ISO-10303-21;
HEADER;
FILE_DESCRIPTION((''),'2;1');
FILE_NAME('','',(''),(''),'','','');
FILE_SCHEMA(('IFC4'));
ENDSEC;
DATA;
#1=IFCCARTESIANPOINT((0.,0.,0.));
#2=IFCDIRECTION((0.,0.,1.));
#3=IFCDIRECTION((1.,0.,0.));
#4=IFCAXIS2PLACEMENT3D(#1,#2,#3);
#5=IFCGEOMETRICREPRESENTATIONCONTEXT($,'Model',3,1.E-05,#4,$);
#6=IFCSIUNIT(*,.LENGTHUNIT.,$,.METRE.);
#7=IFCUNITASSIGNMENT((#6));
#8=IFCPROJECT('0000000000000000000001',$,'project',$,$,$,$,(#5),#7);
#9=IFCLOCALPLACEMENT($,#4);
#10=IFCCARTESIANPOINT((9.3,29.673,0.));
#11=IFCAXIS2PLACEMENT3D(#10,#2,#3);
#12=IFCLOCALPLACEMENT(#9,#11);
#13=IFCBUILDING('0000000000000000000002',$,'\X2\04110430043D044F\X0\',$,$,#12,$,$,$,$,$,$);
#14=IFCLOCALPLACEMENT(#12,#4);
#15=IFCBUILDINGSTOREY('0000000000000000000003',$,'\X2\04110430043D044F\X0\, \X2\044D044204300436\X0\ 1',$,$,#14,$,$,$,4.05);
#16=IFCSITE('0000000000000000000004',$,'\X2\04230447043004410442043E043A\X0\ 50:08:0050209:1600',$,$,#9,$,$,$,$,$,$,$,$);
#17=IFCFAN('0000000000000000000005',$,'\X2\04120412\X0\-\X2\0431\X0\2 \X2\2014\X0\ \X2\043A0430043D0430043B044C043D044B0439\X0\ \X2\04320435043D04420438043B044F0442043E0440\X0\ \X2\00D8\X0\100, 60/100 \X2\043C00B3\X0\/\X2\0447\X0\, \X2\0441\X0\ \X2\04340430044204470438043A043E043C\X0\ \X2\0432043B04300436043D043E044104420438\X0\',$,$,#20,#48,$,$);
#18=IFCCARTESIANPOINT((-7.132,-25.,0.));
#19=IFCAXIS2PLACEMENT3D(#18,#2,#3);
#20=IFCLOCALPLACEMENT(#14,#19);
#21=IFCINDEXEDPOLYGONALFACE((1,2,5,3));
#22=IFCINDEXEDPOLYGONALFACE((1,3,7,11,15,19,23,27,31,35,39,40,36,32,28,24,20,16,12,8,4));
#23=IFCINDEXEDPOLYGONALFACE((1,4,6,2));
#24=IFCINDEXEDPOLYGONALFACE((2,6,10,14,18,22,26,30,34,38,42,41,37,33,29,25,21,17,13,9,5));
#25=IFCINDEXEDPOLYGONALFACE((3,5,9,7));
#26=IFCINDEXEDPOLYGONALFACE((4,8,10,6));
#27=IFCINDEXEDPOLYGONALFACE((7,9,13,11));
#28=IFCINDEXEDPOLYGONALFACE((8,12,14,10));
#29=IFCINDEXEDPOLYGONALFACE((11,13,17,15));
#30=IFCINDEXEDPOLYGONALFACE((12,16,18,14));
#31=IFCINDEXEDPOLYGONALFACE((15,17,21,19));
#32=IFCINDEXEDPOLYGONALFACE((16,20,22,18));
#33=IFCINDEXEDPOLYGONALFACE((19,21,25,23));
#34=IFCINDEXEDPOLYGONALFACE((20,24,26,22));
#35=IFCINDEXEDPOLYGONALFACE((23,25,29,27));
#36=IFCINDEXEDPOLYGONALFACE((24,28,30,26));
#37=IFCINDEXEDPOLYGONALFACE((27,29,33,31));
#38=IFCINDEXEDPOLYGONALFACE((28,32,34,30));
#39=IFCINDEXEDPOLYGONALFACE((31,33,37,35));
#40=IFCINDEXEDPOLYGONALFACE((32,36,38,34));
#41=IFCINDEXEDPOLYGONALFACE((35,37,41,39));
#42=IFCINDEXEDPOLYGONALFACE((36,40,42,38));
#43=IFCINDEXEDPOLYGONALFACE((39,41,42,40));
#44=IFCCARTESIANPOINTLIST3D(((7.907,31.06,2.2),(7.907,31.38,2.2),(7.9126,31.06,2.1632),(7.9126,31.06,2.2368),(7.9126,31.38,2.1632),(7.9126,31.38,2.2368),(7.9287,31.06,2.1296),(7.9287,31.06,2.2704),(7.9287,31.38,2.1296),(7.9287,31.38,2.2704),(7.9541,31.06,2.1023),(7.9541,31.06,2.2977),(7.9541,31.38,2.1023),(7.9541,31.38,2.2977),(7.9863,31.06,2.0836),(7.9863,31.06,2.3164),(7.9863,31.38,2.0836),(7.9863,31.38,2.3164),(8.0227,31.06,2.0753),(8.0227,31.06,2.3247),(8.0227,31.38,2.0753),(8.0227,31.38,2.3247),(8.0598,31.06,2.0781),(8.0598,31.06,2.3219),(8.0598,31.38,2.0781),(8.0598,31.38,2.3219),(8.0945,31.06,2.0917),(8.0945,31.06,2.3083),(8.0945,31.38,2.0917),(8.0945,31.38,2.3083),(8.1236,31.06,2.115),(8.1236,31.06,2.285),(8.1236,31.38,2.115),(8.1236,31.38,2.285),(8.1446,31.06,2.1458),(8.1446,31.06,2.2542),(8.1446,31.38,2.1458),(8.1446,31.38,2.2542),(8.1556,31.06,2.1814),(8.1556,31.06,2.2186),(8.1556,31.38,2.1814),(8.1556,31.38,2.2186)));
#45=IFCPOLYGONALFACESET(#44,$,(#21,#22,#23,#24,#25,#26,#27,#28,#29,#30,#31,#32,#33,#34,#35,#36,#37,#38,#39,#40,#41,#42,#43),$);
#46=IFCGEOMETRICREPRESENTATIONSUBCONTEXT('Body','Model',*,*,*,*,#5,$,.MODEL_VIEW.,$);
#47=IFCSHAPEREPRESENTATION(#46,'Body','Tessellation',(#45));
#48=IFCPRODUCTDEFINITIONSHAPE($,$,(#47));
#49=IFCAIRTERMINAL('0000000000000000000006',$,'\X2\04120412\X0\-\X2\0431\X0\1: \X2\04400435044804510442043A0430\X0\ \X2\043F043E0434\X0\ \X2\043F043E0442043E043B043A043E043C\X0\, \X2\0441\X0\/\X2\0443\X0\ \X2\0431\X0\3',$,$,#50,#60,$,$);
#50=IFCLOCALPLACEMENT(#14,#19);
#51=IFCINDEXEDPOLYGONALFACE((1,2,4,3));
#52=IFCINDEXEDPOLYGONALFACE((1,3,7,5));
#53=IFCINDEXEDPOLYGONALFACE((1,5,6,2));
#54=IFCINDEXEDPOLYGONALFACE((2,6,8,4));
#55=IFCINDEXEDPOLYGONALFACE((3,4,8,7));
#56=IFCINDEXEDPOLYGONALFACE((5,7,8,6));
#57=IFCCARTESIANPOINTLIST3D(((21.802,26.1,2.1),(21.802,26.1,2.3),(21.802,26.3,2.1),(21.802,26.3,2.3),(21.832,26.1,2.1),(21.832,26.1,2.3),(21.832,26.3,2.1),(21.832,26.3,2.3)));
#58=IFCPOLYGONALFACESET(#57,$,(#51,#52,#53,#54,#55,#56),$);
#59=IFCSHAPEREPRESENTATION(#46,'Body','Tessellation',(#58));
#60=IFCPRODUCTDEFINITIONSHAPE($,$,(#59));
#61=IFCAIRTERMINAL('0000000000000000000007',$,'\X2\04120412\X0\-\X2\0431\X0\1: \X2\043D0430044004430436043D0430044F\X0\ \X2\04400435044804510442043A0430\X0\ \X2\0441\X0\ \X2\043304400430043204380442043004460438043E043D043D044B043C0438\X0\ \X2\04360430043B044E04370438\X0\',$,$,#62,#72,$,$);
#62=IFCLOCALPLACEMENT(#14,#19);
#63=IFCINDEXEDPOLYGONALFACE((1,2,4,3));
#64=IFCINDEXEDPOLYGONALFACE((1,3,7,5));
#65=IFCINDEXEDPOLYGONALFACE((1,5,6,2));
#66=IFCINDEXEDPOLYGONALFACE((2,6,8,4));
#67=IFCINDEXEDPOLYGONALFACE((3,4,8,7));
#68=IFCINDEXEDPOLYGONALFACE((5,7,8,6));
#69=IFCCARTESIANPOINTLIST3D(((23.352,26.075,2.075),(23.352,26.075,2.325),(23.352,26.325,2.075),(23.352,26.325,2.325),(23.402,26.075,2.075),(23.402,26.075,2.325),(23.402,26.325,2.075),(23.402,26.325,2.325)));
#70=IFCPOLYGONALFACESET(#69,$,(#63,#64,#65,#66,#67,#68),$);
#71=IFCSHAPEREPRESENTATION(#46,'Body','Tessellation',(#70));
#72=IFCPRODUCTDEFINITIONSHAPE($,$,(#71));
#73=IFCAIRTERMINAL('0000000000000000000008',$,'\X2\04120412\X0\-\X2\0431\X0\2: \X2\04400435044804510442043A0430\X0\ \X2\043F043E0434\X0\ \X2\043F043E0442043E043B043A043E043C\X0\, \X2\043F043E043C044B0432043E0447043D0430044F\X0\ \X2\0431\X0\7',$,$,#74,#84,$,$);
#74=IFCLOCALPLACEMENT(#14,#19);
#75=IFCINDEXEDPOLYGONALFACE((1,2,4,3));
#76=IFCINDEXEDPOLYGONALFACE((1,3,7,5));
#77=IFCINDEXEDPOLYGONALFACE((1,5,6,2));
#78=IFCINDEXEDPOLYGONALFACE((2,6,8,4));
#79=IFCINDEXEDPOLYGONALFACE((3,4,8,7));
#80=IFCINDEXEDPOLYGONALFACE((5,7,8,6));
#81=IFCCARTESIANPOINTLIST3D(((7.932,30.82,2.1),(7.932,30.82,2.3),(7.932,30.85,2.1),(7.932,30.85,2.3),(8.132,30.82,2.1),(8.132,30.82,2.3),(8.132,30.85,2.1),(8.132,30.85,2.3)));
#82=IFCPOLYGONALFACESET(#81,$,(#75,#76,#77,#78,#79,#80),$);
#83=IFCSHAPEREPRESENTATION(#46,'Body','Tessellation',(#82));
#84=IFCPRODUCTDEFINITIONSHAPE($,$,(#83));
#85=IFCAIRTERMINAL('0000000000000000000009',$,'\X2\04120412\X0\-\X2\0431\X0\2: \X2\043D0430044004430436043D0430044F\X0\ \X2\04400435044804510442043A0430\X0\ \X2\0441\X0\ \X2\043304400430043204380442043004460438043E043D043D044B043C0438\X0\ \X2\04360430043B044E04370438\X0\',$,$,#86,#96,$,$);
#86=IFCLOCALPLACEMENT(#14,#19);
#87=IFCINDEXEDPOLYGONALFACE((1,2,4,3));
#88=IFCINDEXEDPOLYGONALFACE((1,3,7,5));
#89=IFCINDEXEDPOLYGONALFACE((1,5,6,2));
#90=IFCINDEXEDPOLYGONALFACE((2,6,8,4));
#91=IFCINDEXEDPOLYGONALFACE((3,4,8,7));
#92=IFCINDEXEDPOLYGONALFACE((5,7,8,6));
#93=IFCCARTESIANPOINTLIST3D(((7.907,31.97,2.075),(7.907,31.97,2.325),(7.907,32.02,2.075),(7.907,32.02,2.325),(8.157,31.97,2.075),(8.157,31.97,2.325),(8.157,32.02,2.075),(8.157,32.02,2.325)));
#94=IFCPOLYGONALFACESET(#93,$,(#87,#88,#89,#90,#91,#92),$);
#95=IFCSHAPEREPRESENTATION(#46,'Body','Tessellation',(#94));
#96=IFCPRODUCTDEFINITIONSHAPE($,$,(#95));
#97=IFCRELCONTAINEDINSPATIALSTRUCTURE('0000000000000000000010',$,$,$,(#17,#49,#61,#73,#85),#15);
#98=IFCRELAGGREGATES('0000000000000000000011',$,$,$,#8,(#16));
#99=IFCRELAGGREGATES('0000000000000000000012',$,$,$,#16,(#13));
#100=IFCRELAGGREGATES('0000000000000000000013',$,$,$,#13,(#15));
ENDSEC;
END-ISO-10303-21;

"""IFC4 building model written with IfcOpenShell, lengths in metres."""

from ifc_helpers import new_model, si_unit, frame, frame_2d, origin_with_axes, origin_2d, place, context, subcontext, project, spatial, rectangle, circle, extrude, element, save


model = new_model("IFC4")

# Units and contexts
model_context = context("Model", 3, precision=1e-05, world=origin_with_axes())
body_context = subcontext(model_context, "Body", "Model", "MODEL_VIEW")
ifc_project = project(units=[si_unit("LENGTHUNIT", "METRE")], contexts=[model_context])

# Site, building, storey
site_placement = place(None, origin_with_axes())
site = spatial("IfcSite", under=ifc_project, at=site_placement, Name="Участок 50:08:0050209:1600")
building_placement = place(site_placement, frame((9.3, 29.673, 0.0), z_axis=(0.0, 0.0, 1.0), x_axis=(1.0, 0.0, 0.0)))
building = spatial("IfcBuilding", under=site, at=building_placement, Name="Баня")
storey_placement = place(building_placement, origin_with_axes())
storey = spatial("IfcBuildingStorey", under=building, at=storey_placement, Name="Баня, этаж 1", Elevation=4.05)

# Fan
fan_1_placement = place(storey_placement, frame((-7.132, -25.0, 0.0), z_axis=(0.0, 0.0, 1.0), x_axis=(1.0, 0.0, 0.0)))
element("IfcFan", 1, at=fan_1_placement, inside=storey, Name="ВВ-б2 — канальный вентилятор Ø100, 60/100 м³/ч, с датчиком влажности", context=body_context, shape_type="SweptSolid", body=[
    extrude(circle(Radius=0.125, at=origin_2d()), frame((8.032, 31.06, 2.2), z_axis=(0.0, 1.0, 0.0), x_axis=(-1.0, 0.0, 0.0)), (0.0, 0.0, 1.0), 0.32),
])

# Air terminals
air_terminal_1_placement = place(storey_placement, frame((-7.132, -25.0, 0.0), z_axis=(0.0, 0.0, 1.0), x_axis=(1.0, 0.0, 0.0)))
element("IfcAirTerminal", 2, at=air_terminal_1_placement, inside=storey, Name="ВВ-б1: решётка под потолком, с/у б3", context=body_context, shape_type="SweptSolid", body=[
    extrude(rectangle(XDim=0.03, YDim=0.2, at=frame_2d((0.015, 0.1))), frame((21.802, 26.1, 2.1), z_axis=(0.0, 0.0, 1.0), x_axis=(1.0, 0.0, 0.0)), (0.0, 0.0, 1.0), 0.2),
])
air_terminal_2_placement = place(storey_placement, frame((-7.132, -25.0, 0.0), z_axis=(0.0, 0.0, 1.0), x_axis=(1.0, 0.0, 0.0)))
element("IfcAirTerminal", 3, at=air_terminal_2_placement, inside=storey, Name="ВВ-б1: наружная решётка с гравитационными жалюзи", context=body_context, shape_type="SweptSolid", body=[
    extrude(rectangle(XDim=0.05, YDim=0.25, at=frame_2d((0.025, 0.125))), frame((23.352, 26.075, 2.075), z_axis=(0.0, 0.0, 1.0), x_axis=(1.0, 0.0, 0.0)), (0.0, 0.0, 1.0), 0.25),
])
air_terminal_3_placement = place(storey_placement, frame((-7.132, -25.0, 0.0), z_axis=(0.0, 0.0, 1.0), x_axis=(1.0, 0.0, 0.0)))
element("IfcAirTerminal", 4, at=air_terminal_3_placement, inside=storey, Name="ВВ-б2: решётка под потолком, помывочная б7", context=body_context, shape_type="SweptSolid", body=[
    extrude(rectangle(XDim=0.2, YDim=0.03, at=frame_2d((0.1, 0.015))), frame((7.932, 30.82, 2.1), z_axis=(0.0, 0.0, 1.0), x_axis=(1.0, 0.0, 0.0)), (0.0, 0.0, 1.0), 0.2),
])
air_terminal_4_placement = place(storey_placement, frame((-7.132, -25.0, 0.0), z_axis=(0.0, 0.0, 1.0), x_axis=(1.0, 0.0, 0.0)))
element("IfcAirTerminal", 5, at=air_terminal_4_placement, inside=storey, Name="ВВ-б2: наружная решётка с гравитационными жалюзи", context=body_context, shape_type="SweptSolid", body=[
    extrude(rectangle(XDim=0.25, YDim=0.05, at=frame_2d((0.125, 0.025))), frame((7.907, 31.97, 2.075), z_axis=(0.0, 0.0, 1.0), x_axis=(1.0, 0.0, 0.0)), (0.0, 0.0, 1.0), 0.25),
])

save(model, "model.ifc")
